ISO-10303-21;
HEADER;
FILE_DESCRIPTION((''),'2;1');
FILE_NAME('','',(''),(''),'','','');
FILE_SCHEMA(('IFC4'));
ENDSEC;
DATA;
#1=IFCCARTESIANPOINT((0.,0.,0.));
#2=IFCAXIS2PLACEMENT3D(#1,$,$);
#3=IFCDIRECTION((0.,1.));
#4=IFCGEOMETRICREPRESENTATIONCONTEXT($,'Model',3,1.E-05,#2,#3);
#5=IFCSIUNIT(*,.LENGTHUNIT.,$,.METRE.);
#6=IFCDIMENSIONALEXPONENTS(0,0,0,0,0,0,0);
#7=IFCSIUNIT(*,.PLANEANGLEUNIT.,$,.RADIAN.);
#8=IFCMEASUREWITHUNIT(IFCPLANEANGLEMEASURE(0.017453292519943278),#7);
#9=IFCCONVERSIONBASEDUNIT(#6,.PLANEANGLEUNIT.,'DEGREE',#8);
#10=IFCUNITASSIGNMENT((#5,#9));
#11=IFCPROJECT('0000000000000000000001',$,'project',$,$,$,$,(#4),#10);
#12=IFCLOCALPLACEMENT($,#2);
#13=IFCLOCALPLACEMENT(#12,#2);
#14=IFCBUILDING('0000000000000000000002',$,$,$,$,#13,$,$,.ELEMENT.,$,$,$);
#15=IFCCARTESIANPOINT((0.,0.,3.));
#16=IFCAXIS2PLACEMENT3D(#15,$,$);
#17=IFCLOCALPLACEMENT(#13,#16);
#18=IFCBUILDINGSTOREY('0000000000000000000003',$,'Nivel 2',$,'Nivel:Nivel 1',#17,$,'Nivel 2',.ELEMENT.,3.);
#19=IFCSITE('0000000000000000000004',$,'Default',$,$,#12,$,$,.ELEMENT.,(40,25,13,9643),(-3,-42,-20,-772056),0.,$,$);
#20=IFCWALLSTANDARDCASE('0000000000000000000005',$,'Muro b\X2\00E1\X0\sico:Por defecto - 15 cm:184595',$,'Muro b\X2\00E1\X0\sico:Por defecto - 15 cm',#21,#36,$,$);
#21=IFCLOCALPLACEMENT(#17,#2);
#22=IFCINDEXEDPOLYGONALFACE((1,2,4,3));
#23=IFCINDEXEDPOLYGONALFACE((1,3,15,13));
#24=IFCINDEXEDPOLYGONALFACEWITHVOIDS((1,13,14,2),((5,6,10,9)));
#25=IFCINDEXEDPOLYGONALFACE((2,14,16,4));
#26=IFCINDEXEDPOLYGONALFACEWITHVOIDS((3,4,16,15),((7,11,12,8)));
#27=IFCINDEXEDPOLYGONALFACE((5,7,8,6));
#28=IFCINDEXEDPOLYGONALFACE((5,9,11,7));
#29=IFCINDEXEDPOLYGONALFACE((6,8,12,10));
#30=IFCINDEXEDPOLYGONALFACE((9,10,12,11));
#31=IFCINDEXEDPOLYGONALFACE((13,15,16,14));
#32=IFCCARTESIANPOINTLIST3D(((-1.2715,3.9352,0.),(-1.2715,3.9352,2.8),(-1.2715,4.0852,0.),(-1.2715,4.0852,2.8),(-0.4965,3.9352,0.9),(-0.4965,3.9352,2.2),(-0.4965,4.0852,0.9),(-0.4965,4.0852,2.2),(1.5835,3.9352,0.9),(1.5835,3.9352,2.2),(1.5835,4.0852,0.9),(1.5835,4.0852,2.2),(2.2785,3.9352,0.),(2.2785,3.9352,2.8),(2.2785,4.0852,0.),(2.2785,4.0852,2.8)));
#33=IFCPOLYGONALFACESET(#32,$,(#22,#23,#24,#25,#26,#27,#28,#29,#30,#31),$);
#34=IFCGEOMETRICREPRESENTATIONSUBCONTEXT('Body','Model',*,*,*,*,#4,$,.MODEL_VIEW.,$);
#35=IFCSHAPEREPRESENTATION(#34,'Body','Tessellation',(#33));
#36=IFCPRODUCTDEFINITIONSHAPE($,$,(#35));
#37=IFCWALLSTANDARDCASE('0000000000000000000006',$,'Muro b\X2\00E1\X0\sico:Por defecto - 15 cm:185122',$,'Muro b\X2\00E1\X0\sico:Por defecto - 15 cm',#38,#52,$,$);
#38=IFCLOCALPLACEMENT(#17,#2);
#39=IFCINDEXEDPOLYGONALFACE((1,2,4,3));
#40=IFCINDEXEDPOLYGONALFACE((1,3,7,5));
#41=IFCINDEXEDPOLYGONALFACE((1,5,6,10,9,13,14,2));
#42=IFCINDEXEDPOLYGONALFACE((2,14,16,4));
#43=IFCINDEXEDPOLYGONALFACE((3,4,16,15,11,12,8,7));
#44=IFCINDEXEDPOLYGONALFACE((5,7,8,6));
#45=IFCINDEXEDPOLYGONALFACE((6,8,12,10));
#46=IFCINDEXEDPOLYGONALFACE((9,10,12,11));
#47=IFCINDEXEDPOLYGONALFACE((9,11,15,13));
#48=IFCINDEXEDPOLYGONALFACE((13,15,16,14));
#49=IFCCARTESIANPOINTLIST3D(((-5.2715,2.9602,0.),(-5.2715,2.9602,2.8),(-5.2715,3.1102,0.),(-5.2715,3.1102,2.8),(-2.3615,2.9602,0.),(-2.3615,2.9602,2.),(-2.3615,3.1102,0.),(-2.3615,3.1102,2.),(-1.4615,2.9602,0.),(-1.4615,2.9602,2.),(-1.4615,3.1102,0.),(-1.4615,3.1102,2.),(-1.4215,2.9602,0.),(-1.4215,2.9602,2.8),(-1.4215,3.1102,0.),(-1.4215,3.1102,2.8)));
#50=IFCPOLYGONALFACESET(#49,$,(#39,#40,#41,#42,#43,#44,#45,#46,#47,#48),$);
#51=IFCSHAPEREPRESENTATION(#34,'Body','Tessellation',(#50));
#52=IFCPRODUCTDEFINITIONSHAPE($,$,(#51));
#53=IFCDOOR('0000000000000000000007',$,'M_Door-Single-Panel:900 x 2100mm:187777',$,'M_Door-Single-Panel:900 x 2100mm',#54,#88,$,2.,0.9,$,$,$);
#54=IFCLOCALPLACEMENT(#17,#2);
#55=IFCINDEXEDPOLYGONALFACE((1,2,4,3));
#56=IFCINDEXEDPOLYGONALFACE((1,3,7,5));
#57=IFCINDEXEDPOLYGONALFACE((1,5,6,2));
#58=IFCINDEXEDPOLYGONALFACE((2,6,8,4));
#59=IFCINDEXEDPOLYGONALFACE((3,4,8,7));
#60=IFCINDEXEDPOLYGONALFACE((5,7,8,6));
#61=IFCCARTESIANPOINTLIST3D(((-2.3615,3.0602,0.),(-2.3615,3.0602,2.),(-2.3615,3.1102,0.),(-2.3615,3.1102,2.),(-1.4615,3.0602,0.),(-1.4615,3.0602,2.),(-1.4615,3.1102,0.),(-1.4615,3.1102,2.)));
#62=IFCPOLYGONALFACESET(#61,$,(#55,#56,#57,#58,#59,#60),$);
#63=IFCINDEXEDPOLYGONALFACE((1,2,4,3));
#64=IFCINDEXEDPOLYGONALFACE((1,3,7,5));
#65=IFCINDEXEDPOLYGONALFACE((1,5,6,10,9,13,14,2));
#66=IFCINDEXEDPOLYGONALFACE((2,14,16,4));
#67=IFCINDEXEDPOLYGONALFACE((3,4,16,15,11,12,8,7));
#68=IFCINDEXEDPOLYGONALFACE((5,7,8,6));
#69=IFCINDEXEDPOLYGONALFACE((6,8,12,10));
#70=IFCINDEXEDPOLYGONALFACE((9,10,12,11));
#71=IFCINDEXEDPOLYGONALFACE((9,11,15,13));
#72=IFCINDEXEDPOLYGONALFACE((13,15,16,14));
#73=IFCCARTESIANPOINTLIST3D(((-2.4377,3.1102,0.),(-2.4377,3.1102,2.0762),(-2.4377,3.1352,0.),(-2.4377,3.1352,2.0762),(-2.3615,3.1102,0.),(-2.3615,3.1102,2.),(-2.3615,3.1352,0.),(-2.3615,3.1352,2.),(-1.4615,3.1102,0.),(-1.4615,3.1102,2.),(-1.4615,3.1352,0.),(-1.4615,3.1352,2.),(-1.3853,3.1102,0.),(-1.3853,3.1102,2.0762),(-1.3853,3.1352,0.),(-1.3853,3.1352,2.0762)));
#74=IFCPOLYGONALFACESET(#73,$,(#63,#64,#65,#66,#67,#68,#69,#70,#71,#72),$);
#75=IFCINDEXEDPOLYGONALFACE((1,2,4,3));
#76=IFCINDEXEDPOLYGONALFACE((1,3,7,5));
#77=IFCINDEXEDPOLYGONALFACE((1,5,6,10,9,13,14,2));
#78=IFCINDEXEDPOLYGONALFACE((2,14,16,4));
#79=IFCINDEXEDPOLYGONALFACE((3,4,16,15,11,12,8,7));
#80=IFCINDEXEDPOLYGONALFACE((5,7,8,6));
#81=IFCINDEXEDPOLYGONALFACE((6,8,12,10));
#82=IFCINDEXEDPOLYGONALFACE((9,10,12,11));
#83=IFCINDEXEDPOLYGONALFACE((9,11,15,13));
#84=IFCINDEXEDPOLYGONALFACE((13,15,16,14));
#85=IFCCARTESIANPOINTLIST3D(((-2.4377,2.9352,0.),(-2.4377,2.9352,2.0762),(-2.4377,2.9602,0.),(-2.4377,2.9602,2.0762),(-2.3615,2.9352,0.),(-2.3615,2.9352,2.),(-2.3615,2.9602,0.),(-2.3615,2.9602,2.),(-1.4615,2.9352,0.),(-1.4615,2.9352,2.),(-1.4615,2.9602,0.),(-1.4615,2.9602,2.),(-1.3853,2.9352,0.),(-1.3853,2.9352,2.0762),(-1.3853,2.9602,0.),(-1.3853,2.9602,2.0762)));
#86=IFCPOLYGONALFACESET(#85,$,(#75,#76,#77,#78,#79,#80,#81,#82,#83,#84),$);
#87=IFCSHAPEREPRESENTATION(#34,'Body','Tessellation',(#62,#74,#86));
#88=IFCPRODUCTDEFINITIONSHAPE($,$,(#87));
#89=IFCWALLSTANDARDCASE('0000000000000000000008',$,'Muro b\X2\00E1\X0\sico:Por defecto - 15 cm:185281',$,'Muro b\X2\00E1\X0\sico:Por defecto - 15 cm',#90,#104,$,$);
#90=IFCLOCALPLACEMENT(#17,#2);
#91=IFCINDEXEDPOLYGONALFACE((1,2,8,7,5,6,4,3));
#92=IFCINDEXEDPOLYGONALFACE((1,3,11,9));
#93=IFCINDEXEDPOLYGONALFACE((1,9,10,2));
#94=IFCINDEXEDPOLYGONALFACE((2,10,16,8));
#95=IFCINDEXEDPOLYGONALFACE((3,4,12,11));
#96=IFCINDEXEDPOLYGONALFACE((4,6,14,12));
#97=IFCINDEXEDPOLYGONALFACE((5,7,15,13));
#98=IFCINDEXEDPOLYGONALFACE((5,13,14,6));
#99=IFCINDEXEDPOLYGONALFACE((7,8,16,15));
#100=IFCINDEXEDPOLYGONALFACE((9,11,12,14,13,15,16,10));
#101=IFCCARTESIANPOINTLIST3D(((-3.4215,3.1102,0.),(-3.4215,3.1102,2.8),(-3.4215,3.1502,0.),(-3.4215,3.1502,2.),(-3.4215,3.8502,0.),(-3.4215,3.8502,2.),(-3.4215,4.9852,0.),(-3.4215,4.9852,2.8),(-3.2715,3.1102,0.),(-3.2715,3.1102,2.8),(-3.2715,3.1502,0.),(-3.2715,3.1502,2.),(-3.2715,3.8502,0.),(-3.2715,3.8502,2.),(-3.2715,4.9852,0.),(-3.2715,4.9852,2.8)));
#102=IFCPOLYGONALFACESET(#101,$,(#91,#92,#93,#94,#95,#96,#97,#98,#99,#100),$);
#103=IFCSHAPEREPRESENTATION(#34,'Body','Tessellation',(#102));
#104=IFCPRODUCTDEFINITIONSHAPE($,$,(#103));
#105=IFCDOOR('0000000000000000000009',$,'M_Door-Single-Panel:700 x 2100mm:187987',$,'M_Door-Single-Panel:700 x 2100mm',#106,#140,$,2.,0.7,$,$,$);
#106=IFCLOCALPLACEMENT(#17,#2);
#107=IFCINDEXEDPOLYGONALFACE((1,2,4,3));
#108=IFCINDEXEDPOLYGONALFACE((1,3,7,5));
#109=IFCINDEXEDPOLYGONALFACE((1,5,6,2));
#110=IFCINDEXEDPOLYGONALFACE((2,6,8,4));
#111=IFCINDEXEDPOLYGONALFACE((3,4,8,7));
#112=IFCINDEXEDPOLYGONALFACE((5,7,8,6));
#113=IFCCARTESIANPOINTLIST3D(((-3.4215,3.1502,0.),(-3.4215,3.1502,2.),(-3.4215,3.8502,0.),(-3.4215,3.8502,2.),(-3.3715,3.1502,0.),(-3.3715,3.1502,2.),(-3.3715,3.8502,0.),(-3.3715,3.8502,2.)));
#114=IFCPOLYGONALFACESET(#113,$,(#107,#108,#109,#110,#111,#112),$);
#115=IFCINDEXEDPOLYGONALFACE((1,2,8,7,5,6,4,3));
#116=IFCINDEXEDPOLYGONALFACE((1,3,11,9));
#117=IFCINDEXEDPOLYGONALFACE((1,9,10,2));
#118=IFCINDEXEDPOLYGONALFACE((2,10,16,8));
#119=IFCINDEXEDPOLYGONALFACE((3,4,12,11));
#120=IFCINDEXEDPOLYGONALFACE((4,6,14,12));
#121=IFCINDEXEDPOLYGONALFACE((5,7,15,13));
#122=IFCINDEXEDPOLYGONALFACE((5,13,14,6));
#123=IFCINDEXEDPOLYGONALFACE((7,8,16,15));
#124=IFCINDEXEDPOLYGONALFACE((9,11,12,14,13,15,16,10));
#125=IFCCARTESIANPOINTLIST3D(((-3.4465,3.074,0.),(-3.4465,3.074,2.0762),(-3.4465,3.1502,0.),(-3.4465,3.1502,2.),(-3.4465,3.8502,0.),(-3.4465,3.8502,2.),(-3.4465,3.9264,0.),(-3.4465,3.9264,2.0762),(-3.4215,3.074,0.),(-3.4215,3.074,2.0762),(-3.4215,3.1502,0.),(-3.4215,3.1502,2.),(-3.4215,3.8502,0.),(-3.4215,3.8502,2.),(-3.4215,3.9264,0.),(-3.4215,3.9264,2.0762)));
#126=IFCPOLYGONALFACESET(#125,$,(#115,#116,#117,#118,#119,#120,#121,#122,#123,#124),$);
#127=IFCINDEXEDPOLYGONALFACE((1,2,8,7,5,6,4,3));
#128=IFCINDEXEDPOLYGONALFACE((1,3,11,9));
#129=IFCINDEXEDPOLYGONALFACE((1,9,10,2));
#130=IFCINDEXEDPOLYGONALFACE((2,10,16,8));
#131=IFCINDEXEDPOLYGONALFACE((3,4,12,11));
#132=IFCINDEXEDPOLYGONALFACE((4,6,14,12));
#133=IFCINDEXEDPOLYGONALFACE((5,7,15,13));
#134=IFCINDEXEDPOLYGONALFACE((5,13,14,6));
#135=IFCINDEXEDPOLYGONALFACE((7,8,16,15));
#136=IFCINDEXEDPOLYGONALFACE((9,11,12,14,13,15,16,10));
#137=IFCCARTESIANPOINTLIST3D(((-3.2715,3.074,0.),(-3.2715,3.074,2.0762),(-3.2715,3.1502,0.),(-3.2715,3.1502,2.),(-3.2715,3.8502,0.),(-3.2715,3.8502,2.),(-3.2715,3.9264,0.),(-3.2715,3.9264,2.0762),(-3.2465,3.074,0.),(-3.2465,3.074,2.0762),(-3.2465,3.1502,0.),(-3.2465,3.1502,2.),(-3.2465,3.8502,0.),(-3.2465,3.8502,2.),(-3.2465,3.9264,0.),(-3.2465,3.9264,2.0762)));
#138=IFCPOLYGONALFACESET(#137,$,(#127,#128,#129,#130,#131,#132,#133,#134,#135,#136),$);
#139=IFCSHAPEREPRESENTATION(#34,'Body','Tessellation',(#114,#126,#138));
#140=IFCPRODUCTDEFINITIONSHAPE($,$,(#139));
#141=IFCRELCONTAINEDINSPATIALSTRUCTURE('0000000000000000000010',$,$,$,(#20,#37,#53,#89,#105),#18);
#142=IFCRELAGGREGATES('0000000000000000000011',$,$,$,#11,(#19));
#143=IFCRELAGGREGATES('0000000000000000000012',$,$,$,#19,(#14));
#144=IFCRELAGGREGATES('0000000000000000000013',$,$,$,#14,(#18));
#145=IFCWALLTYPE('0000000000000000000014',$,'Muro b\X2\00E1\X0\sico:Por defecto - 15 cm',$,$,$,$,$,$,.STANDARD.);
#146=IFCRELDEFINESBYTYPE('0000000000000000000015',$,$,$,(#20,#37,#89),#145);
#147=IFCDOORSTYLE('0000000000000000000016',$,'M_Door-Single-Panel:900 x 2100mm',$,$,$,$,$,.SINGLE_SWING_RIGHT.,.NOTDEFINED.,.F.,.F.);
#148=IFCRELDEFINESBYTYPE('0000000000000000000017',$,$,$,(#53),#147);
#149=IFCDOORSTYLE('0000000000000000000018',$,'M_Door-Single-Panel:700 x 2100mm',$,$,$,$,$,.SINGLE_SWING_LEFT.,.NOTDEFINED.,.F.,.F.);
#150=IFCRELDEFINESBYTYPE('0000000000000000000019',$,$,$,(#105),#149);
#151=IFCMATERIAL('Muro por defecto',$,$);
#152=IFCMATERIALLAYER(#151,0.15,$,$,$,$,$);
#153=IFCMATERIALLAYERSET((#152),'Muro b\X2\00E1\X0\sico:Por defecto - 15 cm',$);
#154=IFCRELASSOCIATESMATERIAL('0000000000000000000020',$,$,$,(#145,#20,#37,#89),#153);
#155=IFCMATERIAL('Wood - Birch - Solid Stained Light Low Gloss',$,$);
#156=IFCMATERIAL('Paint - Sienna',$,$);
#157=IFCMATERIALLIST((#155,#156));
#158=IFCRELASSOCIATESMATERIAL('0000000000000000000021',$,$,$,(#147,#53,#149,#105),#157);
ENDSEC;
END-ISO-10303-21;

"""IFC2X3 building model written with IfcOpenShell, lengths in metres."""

from ifc_helpers import new_model, entity, si_unit, converted_unit, direction, frame, frame_2d, origin, origin_2d_with_axis, place, context, subcontext, project, spatial, polyline, rectangle, outline, extrude, clip, bounded_halfspace, source, transform, mapped, material, material_list, layer, layer_set, layer_usage, type_object, type_shapes, element, fill, save


model = new_model("IFC2X3")

# Units and contexts
model_context = context("Model", 3, precision=1e-05, world=origin(), true_north=direction((0.0, 1.0)))
body_context = subcontext(model_context, "Body", "Model", "MODEL_VIEW")
ifc_project = project(units=[si_unit("LENGTHUNIT", "METRE"), converted_unit("PLANEANGLEUNIT", "DEGREE", entity("IfcPlaneAngleMeasure", 0.017453292519943278), si_unit("PLANEANGLEUNIT", "RADIAN"), dimensions=[0, 0, 0, 0, 0, 0, 0])], contexts=[model_context])

# Site, building, storey
site_placement = place(None, origin())
site = spatial("IfcSite", under=ifc_project, at=site_placement, Name="Default", CompositionType="ELEMENT", RefLatitude=(40, 25, 13, 9643), RefLongitude=(-3, -42, -20, -772056), RefElevation=0.0)
building_placement = place(site_placement, origin())
building = spatial("IfcBuilding", under=site, at=building_placement, CompositionType="ELEMENT")
storey_placement = place(building_placement, frame((0.0, 0.0, 3.0)))
storey = spatial("IfcBuildingStorey", under=building, at=storey_placement, Name="Nivel 2", ObjectType="Nivel:Nivel 1", LongName="Nivel 2", CompositionType="ELEMENT", Elevation=3.0)

# Shared definitions
ifc_material_1 = material(Name="Muro por defecto")
ifc_layer_1 = layer(ifc_material_1, 0.15)
ifc_layer_set_1 = layer_set([ifc_layer_1], Name="Muro básico:Por defecto - 15 cm")
wall_type = type_object("IfcWallType", Name="Muro básico:Por defecto - 15 cm", PredefinedType="STANDARD", material=ifc_layer_set_1)

# Wall, opening
ifc_layer_usage_1 = layer_usage(ifc_layer_set_1, "AXIS2", "POSITIVE", -0.075)
wall_1_placement = place(storey_placement, frame((-1.2715, 4.0102, 0.0)))
wall_1 = element("IfcWallStandardCase", 1, at=wall_1_placement, inside=storey, type_object=wall_type, material=ifc_layer_usage_1, Name="Muro básico:Por defecto - 15 cm:184595", ObjectType="Muro básico:Por defecto - 15 cm", context=body_context, shape_type="Clipping", body=[
    clip(extrude(rectangle(XDim=3.55, YDim=0.15, at=frame_2d((1.775, 0.0), x_axis=(-1.0, 0.0))), origin(), (0.0, 0.0, 1.0), 2.8), bounded_halfspace(frame((0.0, -0.075, 2.8), z_axis=(0.0, 0.0, -1.0), x_axis=(1.0, 0.0, 0.0)), True, frame((0.0, -0.075, 2.8)), polyline([(0.0, 0.0), (3.55, 0.0), (3.55, 0.15), (0.0, 0.15), (0.0, 0.0)]))),
])
opening_1_placement = place(wall_1_placement, frame((0.775, -0.075, 0.9)))
element("IfcOpeningElement", 2, at=opening_1_placement, cuts=wall_1, ObjectType="Opening", context=body_context, shape_type="SweptSolid", body=[
    extrude(rectangle(XDim=1.3, YDim=2.08, at=frame_2d((0.65, 1.04), x_axis=(-1.0, 0.0))), frame((0.0, 0.0, 0.0), z_axis=(0.0, 1.0, 0.0), x_axis=(0.0, 0.0, 1.0)), (0.0, 0.0, 1.0), 0.15),
])

# Walls, openings, doors
ifc_layer_usage_2 = layer_usage(ifc_layer_set_1, "AXIS2", "POSITIVE", -0.075)
wall_2_placement = place(storey_placement, frame((-5.2715, 3.0352, 0.0)))
wall_2 = element("IfcWallStandardCase", 3, at=wall_2_placement, inside=storey, type_object=wall_type, material=ifc_layer_usage_2, Name="Muro básico:Por defecto - 15 cm:185122", ObjectType="Muro básico:Por defecto - 15 cm", context=body_context, shape_type="Clipping", body=[
    clip(extrude(rectangle(XDim=3.85, YDim=0.15, at=frame_2d((1.925, 0.0), x_axis=(-1.0, 0.0))), origin(), (0.0, 0.0, 1.0), 2.8), bounded_halfspace(frame((3.85, 0.075, 2.8), z_axis=(0.0, 0.0, -1.0), x_axis=(1.0, 0.0, 0.0)), True, frame((3.85, 0.075, 2.8)), polyline([(0.0, 0.0), (-1.85, 0.0), (-2.0, 0.0), (-3.85, 0.0), (-3.85, -0.075), (0.0, -0.075), (0.0, 0.0)]))),
])
opening_2_placement = place(wall_2_placement, frame((2.91, -0.075, 0.0)))
opening_2 = element("IfcOpeningElement", 4, at=opening_2_placement, cuts=wall_2, ObjectType="Opening", context=body_context, shape_type="SweptSolid", body=[
    extrude(rectangle(XDim=0.9, YDim=2.0, at=frame_2d((1.0, 0.45), x_axis=(0.0, 1.0))), frame((0.0, 0.0, 0.0), z_axis=(0.0, 1.0, 0.0), x_axis=(0.0, 0.0, 1.0)), (0.0, 0.0, 1.0), 0.15),
])
ifc_material_2 = material(Name="Wood - Birch - Solid Stained Light Low Gloss")
ifc_material_3 = material(Name="Paint - Sienna")
ifc_material_list_1 = material_list([ifc_material_2, ifc_material_3])
door_style_1 = type_object("IfcDoorStyle", Name="M_Door-Single-Panel:900 x 2100mm", ConstructionType="NOTDEFINED", OperationType="SINGLE_SWING_RIGHT", ParameterTakesPrecedence=False, Sizeable=False, material=ifc_material_list_1)
shared_shape_1 = source(origin(), body_context, "Body", "SweptSolid", [
    extrude(rectangle(XDim=0.05, YDim=0.9, at=origin_2d_with_axis()), frame((0.45, 0.125, 0.0), z_axis=(0.0, 0.0, 1.0), x_axis=(0.0, 1.0, 0.0)), (0.0, 0.0, 1.0), 2.0),
    extrude(outline(polyline([(-0.5262, -1.0571), (0.5262, -1.0571), (0.5262, 1.0191), (0.45, 1.0191), (0.45, -0.981), (-0.45, -0.981), (-0.45, 1.0191), (-0.5262, 1.0191), (-0.5262, -1.0571)])), frame((0.45, 0.15, 1.0191), z_axis=(0.0, 1.0, 0.0), x_axis=(1.0, 0.0, 0.0)), (0.0, 0.0, 1.0), 0.025),
    extrude(outline(polyline([(-1.0571, -0.5262), (1.019, -0.5262), (1.019, -0.45), (-0.9809, -0.45), (-0.9809, 0.45), (1.019, 0.45), (1.019, 0.5262), (-1.0571, 0.5262), (-1.0571, -0.5262)])), frame((0.45, -0.025, 1.019), z_axis=(0.0, 1.0, 0.0), x_axis=(0.0, 0.0, -1.0)), (0.0, 0.0, 1.0), 0.025),
])
type_shapes(door_style_1, [shared_shape_1])
door_1_placement = place(opening_2_placement, origin())
door_1 = element("IfcDoor", 5, at=door_1_placement, inside=storey, type_object=door_style_1, material=ifc_material_list_1, Name="M_Door-Single-Panel:900 x 2100mm:187777", ObjectType="M_Door-Single-Panel:900 x 2100mm", OverallHeight=2.0, OverallWidth=0.9, context=body_context, shape_type="MappedRepresentation", body=[
    mapped(shared_shape_1, transform((0.0, 0.0, 0.0), scale=1.0)),
])
fill(opening_2, door_1)
ifc_layer_usage_3 = layer_usage(ifc_layer_set_1, "AXIS2", "POSITIVE", -0.075)
wall_3_placement = place(storey_placement, frame((-3.3465, 4.9852, 0.0), z_axis=(0.0, 0.0, 1.0), x_axis=(0.0, -1.0, 0.0)))
wall_3 = element("IfcWallStandardCase", 6, at=wall_3_placement, inside=storey, type_object=wall_type, material=ifc_layer_usage_3, Name="Muro básico:Por defecto - 15 cm:185281", ObjectType="Muro básico:Por defecto - 15 cm", context=body_context, shape_type="Clipping", body=[
    clip(extrude(rectangle(XDim=1.875, YDim=0.15, at=frame_2d((0.9375, 0.0), x_axis=(1.0, 0.0))), origin(), (0.0, 0.0, 1.0), 2.8), bounded_halfspace(frame((0.0, -0.075, 2.8), z_axis=(0.0, 0.0, -1.0), x_axis=(0.0, 1.0, 0.0)), True, frame((0.0, -0.075, 2.8)), polyline([(0.0, 0.0), (1.875, 0.0), (1.875, 0.15), (0.0, 0.15), (0.0, 0.0)]))),
])
opening_3_placement = place(wall_3_placement, frame((1.835, 0.075, 0.0)))
opening_3 = element("IfcOpeningElement", 7, at=opening_3_placement, cuts=wall_3, ObjectType="Opening", context=body_context, shape_type="SweptSolid", body=[
    extrude(rectangle(XDim=0.7, YDim=2.0, at=frame_2d((1.0, 0.35), x_axis=(0.0, -1.0))), frame((0.0, 0.0, 0.0), z_axis=(0.0, -1.0, 0.0), x_axis=(0.0, 0.0, 1.0)), (0.0, 0.0, 1.0), 0.15),
])
door_style_2 = type_object("IfcDoorStyle", Name="M_Door-Single-Panel:700 x 2100mm", ConstructionType="NOTDEFINED", OperationType="SINGLE_SWING_LEFT", ParameterTakesPrecedence=False, Sizeable=False, material=ifc_material_list_1)
shared_shape_2 = source(origin(), body_context, "Body", "SweptSolid", [
    extrude(rectangle(XDim=0.7, YDim=0.05, at=origin_2d_with_axis()), frame((0.35, 0.125, 0.0)), (0.0, 0.0, 1.0), 2.0),
    extrude(outline(polyline([(-0.4262, -1.0571), (0.4262, -1.0571), (0.4262, 1.0191), (0.35, 1.0191), (0.35, -0.981), (-0.35, -0.981), (-0.35, 1.0191), (-0.4262, 1.0191), (-0.4262, -1.0571)])), frame((0.35, 0.175, 1.0191), z_axis=(0.0, -1.0, 0.0), x_axis=(-1.0, 0.0, 0.0)), (0.0, 0.0, 1.0), 0.025),
    extrude(outline(polyline([(-1.0571, -0.4262), (1.019, -0.4262), (1.019, -0.35), (-0.9809, -0.35), (-0.9809, 0.35), (1.019, 0.35), (1.019, 0.4262), (-1.0571, 0.4262), (-1.0571, -0.4262)])), frame((0.35, 0.0, 1.019), z_axis=(0.0, -1.0, 0.0), x_axis=(0.0, 0.0, -1.0)), (0.0, 0.0, 1.0), 0.025),
])
type_shapes(door_style_2, [shared_shape_2])
door_2_placement = place(opening_3_placement, frame((0.0, 0.0, 0.0), z_axis=(0.0, 0.0, 1.0), x_axis=(-1.0, 0.0, 0.0)))
door_2 = element("IfcDoor", 8, at=door_2_placement, inside=storey, type_object=door_style_2, material=ifc_material_list_1, Name="M_Door-Single-Panel:700 x 2100mm:187987", ObjectType="M_Door-Single-Panel:700 x 2100mm", OverallHeight=2.0, OverallWidth=0.7, context=body_context, shape_type="MappedRepresentation", body=[
    mapped(shared_shape_2, transform((0.0, 0.0, 0.0), scale=1.0)),
])
fill(opening_3, door_2)

save(model, "model.ifc")
